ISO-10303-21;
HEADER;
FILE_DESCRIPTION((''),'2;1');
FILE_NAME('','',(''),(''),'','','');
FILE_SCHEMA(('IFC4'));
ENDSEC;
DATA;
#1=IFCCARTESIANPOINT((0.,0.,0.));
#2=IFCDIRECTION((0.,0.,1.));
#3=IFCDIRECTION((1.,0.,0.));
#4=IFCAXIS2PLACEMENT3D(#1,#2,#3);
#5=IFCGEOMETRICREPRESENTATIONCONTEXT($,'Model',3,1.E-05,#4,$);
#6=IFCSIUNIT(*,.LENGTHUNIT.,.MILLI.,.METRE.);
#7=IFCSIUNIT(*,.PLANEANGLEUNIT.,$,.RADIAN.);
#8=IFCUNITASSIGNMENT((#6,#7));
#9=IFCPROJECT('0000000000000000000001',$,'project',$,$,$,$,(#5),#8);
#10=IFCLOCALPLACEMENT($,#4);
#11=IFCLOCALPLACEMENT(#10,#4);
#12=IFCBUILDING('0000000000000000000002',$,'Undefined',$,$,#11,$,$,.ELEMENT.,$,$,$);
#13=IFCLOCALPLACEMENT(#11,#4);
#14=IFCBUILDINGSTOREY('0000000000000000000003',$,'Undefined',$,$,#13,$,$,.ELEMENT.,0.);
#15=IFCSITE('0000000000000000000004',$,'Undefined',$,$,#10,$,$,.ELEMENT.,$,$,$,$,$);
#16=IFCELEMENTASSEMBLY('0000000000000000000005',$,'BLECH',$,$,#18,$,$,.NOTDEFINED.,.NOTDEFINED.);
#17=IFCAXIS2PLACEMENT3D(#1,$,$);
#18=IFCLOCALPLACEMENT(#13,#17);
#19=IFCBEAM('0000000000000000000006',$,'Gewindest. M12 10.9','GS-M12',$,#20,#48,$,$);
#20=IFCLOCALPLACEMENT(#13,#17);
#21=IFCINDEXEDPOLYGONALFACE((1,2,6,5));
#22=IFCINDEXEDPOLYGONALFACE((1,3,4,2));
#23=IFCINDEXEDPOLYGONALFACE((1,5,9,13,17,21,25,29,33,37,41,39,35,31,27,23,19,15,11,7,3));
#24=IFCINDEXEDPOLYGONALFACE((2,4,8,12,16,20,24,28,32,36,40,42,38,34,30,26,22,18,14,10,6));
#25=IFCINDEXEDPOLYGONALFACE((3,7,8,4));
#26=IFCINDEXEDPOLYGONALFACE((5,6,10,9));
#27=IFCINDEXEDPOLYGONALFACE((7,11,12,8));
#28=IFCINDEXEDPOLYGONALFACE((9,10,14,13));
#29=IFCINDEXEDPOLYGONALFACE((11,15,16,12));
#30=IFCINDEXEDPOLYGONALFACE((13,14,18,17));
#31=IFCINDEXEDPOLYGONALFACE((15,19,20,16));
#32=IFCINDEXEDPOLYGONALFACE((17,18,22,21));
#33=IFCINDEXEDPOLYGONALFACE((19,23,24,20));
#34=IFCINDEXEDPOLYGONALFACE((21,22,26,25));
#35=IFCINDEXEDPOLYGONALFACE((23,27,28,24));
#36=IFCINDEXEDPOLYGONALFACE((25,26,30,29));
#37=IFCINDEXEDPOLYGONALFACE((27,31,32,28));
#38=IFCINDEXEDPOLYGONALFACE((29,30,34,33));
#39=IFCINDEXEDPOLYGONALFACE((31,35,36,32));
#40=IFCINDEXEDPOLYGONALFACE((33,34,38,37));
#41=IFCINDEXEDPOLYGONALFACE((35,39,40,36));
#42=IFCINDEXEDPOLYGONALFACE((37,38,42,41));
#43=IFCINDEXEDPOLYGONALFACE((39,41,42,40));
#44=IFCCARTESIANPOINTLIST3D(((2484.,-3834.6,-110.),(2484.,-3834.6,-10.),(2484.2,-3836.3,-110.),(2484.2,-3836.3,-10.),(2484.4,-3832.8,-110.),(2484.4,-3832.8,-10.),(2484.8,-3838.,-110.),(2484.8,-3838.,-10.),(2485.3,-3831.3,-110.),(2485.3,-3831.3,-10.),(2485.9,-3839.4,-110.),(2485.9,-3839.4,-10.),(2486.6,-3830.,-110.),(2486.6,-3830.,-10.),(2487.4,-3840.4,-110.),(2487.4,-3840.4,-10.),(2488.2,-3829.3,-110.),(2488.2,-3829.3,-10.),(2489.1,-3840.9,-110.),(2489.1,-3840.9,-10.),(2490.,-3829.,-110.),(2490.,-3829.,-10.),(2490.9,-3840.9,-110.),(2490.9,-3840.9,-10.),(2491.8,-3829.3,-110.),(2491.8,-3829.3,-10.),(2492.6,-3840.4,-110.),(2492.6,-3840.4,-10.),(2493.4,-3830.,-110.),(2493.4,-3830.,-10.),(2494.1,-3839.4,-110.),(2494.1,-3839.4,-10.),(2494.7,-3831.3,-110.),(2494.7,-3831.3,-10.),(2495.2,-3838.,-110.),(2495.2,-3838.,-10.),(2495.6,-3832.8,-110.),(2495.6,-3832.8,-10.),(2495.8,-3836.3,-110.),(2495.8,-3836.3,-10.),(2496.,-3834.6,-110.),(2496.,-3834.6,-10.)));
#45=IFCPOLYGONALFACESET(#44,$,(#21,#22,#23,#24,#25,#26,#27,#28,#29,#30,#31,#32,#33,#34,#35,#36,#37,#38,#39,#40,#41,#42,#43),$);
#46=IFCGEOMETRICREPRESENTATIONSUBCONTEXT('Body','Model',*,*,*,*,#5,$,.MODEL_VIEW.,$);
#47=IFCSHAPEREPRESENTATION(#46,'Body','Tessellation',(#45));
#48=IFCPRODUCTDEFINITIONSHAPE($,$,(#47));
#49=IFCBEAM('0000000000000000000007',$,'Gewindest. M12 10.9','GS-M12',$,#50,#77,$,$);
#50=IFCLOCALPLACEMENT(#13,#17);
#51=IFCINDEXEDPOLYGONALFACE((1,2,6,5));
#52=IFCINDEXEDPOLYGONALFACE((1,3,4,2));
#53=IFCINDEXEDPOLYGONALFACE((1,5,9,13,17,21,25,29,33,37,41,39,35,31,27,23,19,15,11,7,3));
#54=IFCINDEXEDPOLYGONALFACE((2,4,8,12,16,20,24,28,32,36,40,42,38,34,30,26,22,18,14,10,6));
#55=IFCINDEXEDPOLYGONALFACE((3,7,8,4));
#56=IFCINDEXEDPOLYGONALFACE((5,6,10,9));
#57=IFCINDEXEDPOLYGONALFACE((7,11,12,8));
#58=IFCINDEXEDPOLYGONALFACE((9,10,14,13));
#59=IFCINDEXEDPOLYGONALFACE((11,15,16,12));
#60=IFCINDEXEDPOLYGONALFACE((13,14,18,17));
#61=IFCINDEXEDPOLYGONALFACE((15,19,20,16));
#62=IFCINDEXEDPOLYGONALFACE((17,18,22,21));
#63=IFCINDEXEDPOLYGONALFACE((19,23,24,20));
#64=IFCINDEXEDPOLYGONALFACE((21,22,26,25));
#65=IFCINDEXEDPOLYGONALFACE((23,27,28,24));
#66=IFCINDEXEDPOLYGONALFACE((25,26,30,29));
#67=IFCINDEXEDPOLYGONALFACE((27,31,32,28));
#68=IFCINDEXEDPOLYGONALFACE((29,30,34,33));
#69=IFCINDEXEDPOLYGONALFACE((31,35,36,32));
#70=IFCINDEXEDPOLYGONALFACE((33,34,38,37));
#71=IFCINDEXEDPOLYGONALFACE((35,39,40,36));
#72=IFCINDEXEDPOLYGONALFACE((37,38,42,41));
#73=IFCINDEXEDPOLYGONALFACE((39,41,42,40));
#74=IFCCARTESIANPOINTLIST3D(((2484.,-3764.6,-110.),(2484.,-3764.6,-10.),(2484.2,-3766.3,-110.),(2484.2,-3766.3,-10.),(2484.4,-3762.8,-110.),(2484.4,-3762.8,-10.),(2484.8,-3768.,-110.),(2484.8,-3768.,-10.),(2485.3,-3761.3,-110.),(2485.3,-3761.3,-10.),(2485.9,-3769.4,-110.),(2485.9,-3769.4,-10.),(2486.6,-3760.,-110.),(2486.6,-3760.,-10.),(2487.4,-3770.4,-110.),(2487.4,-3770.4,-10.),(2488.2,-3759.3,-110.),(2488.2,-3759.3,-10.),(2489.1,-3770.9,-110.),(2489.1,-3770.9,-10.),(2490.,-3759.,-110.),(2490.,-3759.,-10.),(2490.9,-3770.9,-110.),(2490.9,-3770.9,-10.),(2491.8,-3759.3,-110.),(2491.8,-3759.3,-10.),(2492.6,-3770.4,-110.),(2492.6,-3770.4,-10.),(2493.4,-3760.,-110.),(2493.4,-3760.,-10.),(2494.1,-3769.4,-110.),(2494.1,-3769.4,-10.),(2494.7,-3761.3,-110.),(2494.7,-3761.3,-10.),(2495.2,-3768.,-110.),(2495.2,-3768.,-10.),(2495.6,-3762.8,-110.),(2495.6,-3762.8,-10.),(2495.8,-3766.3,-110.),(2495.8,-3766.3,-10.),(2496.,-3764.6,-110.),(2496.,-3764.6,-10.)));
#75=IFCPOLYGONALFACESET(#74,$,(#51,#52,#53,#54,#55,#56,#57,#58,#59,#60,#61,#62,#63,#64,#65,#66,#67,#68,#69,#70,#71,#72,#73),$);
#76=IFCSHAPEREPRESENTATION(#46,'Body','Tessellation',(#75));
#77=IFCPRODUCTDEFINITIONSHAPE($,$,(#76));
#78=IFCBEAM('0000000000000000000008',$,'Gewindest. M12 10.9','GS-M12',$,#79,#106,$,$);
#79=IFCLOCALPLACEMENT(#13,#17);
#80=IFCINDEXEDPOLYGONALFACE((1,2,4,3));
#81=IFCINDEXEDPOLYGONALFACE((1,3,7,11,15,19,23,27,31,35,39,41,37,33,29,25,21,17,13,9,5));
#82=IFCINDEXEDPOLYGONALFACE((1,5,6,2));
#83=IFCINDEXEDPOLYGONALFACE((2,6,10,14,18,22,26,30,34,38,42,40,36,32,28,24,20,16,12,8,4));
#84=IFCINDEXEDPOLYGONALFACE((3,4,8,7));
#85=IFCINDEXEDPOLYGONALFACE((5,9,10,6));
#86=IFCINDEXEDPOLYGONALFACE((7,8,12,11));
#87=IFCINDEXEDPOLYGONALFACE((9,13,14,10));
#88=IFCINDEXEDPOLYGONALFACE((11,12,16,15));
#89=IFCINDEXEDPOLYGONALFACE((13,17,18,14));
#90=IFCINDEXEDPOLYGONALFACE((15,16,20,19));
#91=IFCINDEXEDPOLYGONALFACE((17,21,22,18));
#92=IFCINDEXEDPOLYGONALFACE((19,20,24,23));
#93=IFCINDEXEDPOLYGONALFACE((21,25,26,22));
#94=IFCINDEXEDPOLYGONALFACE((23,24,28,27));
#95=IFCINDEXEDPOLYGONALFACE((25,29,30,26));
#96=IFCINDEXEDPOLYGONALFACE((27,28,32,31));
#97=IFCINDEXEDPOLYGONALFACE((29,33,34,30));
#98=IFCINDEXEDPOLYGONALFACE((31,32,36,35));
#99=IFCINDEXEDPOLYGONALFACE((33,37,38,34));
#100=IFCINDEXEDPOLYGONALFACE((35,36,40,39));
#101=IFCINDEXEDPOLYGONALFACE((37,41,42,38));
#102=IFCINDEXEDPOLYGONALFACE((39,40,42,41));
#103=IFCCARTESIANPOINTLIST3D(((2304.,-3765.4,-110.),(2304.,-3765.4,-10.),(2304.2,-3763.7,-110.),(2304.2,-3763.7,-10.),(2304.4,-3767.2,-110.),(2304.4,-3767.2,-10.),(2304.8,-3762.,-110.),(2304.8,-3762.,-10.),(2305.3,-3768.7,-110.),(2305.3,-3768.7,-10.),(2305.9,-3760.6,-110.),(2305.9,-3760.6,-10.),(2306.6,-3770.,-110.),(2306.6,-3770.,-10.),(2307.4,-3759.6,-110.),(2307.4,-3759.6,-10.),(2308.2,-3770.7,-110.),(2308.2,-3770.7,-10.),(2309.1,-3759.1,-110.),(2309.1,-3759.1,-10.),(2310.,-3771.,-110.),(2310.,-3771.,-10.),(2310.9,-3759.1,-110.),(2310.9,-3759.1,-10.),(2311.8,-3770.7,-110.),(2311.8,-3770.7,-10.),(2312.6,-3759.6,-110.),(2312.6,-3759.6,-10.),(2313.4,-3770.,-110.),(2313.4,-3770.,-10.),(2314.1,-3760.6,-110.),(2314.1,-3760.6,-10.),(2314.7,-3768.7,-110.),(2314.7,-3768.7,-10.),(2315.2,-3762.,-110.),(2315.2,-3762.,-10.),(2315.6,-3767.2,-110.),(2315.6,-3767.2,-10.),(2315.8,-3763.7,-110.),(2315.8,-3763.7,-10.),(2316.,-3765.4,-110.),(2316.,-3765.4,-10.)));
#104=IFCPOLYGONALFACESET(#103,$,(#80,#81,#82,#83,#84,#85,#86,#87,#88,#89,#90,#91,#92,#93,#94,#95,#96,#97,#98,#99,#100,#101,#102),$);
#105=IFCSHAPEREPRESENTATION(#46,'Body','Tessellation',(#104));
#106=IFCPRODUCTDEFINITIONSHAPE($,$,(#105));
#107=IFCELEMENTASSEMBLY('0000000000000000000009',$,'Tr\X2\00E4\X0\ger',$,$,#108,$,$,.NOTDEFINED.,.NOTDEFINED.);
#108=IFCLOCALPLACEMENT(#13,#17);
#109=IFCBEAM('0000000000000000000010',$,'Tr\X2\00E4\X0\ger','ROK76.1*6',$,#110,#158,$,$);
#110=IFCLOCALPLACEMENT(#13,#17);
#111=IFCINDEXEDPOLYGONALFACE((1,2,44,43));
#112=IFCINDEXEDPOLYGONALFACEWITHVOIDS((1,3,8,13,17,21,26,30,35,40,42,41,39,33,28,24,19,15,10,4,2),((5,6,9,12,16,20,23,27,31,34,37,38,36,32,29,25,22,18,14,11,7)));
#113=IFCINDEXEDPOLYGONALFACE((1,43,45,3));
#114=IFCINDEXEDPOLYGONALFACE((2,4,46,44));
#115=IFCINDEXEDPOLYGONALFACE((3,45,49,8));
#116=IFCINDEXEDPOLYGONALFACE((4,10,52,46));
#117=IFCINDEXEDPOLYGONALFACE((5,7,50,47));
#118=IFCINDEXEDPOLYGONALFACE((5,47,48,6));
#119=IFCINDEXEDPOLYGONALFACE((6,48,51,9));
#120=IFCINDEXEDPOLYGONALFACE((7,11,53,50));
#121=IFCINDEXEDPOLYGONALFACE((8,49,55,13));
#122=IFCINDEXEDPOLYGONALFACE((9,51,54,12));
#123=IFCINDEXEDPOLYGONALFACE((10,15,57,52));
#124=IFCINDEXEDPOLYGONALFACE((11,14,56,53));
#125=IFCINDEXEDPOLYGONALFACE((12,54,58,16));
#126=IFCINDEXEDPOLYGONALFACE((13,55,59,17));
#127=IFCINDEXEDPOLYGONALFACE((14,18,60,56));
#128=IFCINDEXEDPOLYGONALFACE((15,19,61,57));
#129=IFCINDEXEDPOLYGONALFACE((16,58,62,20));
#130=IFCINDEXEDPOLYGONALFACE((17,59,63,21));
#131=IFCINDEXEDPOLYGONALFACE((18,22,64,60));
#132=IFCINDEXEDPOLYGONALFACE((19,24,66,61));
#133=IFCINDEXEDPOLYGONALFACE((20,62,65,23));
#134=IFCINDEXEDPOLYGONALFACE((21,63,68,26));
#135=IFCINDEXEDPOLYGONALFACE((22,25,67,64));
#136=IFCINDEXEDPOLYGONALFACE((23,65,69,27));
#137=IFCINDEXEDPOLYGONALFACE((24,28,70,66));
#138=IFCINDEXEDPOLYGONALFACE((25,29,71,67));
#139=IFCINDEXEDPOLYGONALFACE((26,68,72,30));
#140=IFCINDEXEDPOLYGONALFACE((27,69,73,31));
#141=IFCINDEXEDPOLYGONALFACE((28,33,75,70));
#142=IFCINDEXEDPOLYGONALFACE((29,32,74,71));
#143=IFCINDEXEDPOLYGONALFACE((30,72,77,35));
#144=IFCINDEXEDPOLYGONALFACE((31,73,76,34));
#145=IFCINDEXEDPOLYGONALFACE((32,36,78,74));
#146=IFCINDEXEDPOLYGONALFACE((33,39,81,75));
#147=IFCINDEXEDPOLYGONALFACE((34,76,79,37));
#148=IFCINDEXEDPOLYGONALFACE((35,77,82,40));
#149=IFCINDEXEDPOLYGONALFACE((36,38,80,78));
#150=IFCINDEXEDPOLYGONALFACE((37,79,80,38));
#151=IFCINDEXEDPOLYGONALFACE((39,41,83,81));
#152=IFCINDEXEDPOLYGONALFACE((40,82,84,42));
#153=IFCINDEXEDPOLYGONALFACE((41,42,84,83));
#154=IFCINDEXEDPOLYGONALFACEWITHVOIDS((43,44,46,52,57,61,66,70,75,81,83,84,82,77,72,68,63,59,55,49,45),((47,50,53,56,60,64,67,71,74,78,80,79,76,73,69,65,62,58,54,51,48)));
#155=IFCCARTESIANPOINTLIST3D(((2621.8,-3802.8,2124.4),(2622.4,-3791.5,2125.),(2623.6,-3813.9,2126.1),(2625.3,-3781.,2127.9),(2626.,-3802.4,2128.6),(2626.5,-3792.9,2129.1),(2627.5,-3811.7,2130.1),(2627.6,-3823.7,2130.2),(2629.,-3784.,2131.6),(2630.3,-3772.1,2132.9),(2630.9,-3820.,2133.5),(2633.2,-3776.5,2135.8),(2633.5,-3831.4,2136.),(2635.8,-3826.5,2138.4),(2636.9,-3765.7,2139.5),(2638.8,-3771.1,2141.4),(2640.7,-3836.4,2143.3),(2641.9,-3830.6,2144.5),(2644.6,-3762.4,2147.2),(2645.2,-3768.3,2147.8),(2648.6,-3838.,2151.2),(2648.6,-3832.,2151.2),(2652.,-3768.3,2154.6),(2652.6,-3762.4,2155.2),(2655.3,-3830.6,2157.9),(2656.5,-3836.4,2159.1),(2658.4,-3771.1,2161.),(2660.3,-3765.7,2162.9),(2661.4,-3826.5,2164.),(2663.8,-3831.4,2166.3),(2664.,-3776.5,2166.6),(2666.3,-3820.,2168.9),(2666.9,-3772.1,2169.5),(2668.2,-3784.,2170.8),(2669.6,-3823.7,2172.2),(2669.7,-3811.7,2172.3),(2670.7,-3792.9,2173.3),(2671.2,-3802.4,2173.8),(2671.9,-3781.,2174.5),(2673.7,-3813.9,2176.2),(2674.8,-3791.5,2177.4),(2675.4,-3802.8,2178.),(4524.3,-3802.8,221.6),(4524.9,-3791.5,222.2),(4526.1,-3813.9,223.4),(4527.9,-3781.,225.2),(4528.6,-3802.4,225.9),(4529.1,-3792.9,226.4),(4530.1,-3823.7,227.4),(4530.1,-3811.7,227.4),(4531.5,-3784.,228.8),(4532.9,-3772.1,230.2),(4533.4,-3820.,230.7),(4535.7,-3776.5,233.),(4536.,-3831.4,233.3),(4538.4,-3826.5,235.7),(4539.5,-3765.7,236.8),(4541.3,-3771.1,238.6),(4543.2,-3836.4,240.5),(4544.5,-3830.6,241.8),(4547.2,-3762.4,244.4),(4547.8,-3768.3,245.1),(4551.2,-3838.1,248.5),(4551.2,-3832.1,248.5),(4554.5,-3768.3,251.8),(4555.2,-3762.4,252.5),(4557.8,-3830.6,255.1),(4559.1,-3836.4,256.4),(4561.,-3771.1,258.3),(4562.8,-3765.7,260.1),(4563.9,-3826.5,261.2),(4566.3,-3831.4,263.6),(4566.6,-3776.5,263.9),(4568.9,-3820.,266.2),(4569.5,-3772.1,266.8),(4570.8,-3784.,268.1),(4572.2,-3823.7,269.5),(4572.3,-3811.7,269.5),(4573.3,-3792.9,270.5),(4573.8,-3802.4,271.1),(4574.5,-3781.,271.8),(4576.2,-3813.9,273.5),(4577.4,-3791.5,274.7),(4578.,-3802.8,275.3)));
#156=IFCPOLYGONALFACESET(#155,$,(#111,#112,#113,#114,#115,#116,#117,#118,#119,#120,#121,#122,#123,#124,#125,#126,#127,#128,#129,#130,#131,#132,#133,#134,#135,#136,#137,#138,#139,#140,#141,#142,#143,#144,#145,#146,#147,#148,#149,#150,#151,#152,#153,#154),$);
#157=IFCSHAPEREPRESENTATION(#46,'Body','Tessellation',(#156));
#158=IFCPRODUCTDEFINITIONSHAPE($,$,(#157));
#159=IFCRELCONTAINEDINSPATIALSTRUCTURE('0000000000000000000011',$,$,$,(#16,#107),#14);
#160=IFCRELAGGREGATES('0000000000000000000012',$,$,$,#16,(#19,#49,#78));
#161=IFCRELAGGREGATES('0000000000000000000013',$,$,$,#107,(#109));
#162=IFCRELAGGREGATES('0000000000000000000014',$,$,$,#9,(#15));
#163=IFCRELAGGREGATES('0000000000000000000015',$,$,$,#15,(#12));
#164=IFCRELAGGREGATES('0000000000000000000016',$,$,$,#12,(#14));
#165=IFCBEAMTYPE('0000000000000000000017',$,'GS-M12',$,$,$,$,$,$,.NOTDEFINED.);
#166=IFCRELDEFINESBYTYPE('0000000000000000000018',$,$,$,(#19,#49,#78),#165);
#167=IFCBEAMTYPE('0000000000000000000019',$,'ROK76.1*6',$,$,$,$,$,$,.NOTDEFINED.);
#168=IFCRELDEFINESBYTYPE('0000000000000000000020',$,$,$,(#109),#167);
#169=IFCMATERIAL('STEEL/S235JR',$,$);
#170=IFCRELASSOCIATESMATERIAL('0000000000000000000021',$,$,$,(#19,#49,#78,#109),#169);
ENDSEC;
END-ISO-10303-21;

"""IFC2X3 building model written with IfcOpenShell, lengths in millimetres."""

from ifc_helpers import new_model, si_unit, frame, origin_with_axes, origin_2d_with_axis, place, context, subcontext, project, spatial, circle, hollow_circle, extrude, material, type_object, element, aggregate, save


model = new_model("IFC2X3")

# Units and contexts
model_context = context("Model", 3, precision=1e-05, world=origin_with_axes())
body_context = subcontext(model_context, "Body", "Model", "MODEL_VIEW")
ifc_project = project(units=[si_unit("LENGTHUNIT", "METRE", prefix="MILLI"), si_unit("PLANEANGLEUNIT", "RADIAN")], contexts=[model_context])

# Site, building, storey
site_placement = place(None, origin_with_axes())
site = spatial("IfcSite", under=ifc_project, at=site_placement, Name="Undefined", CompositionType="ELEMENT")
building_placement = place(site_placement, origin_with_axes())
building = spatial("IfcBuilding", under=site, at=building_placement, Name="Undefined", CompositionType="ELEMENT")
storey_placement = place(building_placement, origin_with_axes())
storey = spatial("IfcBuildingStorey", under=building, at=storey_placement, Name="Undefined", CompositionType="ELEMENT", Elevation=0.0)

# Element assembly, beams
assembly_1_placement = place(storey_placement, origin_with_axes())
assembly_1 = element("IfcElementAssembly", 1, at=assembly_1_placement, inside=storey, Name="BLECH", AssemblyPlace="NOTDEFINED", PredefinedType="NOTDEFINED")
ifc_material_1 = material(Name="STEEL/S235JR")
beam_type_1 = type_object("IfcBeamType", Name="GS-M12", PredefinedType="NOTDEFINED")
beam_1_placement = place(assembly_1_placement, frame((2490.0, -3835.0, -10.0), z_axis=(-1.0, 0.0, 0.0), x_axis=(0.0, 0.0, -1.0)))
beam_1 = element("IfcBeam", 2, at=beam_1_placement, type_object=beam_type_1, material=ifc_material_1, Name="Gewindest. M12 10.9", Description="GS-M12", context=body_context, shape_type="SweptSolid", body=[
    extrude(circle(Radius=6.0, at=origin_2d_with_axis()), frame((100.0, 0.0, 0.0), z_axis=(-1.0, 0.0, 0.0), x_axis=(0.0, -1.0, 0.0)), (0.0, 0.0, 1.0), 100.0),
])
beam_2_placement = place(assembly_1_placement, frame((2490.0, -3765.0, -10.0), z_axis=(-1.0, 0.0, 0.0), x_axis=(0.0, 0.0, -1.0)))
beam_2 = element("IfcBeam", 3, at=beam_2_placement, type_object=beam_type_1, material=ifc_material_1, Name="Gewindest. M12 10.9", Description="GS-M12", context=body_context, shape_type="SweptSolid", body=[
    extrude(circle(Radius=6.0, at=origin_2d_with_axis()), frame((100.0, 0.0, 0.0), z_axis=(-1.0, 0.0, 0.0), x_axis=(0.0, -1.0, 0.0)), (0.0, 0.0, 1.0), 100.0),
])
beam_3_placement = place(assembly_1_placement, frame((2310.0, -3765.0, -10.0), z_axis=(1.0, 0.0, 0.0), x_axis=(0.0, 0.0, -1.0)))
beam_3 = element("IfcBeam", 4, at=beam_3_placement, type_object=beam_type_1, material=ifc_material_1, Name="Gewindest. M12 10.9", Description="GS-M12", context=body_context, shape_type="SweptSolid", body=[
    extrude(circle(Radius=6.0, at=origin_2d_with_axis()), frame((100.0, 0.0, 0.0), z_axis=(-1.0, 0.0, 0.0), x_axis=(0.0, -1.0, 0.0)), (0.0, 0.0, 1.0), 100.0),
])
aggregate(assembly_1, [beam_1, beam_2, beam_3])

# Element assembly, beam
assembly_2_placement = place(storey_placement, origin_with_axes())
assembly_2 = element("IfcElementAssembly", 5, at=assembly_2_placement, inside=storey, Name="Träger", AssemblyPlace="NOTDEFINED", PredefinedType="NOTDEFINED")
beam_type_2 = type_object("IfcBeamType", Name="ROK76.1*6", PredefinedType="NOTDEFINED")
beam_4_placement = place(assembly_2_placement, frame((2648.6, -3800.0, 2151.2), z_axis=(0.707141, 0.0, 0.707072), x_axis=(0.707072, 0.0, -0.707141)))
beam_4 = element("IfcBeam", 6, at=beam_4_placement, type_object=beam_type_2, material=ifc_material_1, Name="Träger", Description="ROK76.1*6", context=body_context, shape_type="SweptSolid", body=[
    extrude(hollow_circle(Radius=38.0, WallThickness=6.0, at=origin_2d_with_axis()), frame((2690.8, 0.0, 0.0), z_axis=(-1.0, 0.0, 0.0), x_axis=(0.0, -1.0, 0.0)), (0.0, 0.0, 1.0), 2690.8),
])

aggregate(assembly_2, [beam_4])

save(model, "model.ifc")
